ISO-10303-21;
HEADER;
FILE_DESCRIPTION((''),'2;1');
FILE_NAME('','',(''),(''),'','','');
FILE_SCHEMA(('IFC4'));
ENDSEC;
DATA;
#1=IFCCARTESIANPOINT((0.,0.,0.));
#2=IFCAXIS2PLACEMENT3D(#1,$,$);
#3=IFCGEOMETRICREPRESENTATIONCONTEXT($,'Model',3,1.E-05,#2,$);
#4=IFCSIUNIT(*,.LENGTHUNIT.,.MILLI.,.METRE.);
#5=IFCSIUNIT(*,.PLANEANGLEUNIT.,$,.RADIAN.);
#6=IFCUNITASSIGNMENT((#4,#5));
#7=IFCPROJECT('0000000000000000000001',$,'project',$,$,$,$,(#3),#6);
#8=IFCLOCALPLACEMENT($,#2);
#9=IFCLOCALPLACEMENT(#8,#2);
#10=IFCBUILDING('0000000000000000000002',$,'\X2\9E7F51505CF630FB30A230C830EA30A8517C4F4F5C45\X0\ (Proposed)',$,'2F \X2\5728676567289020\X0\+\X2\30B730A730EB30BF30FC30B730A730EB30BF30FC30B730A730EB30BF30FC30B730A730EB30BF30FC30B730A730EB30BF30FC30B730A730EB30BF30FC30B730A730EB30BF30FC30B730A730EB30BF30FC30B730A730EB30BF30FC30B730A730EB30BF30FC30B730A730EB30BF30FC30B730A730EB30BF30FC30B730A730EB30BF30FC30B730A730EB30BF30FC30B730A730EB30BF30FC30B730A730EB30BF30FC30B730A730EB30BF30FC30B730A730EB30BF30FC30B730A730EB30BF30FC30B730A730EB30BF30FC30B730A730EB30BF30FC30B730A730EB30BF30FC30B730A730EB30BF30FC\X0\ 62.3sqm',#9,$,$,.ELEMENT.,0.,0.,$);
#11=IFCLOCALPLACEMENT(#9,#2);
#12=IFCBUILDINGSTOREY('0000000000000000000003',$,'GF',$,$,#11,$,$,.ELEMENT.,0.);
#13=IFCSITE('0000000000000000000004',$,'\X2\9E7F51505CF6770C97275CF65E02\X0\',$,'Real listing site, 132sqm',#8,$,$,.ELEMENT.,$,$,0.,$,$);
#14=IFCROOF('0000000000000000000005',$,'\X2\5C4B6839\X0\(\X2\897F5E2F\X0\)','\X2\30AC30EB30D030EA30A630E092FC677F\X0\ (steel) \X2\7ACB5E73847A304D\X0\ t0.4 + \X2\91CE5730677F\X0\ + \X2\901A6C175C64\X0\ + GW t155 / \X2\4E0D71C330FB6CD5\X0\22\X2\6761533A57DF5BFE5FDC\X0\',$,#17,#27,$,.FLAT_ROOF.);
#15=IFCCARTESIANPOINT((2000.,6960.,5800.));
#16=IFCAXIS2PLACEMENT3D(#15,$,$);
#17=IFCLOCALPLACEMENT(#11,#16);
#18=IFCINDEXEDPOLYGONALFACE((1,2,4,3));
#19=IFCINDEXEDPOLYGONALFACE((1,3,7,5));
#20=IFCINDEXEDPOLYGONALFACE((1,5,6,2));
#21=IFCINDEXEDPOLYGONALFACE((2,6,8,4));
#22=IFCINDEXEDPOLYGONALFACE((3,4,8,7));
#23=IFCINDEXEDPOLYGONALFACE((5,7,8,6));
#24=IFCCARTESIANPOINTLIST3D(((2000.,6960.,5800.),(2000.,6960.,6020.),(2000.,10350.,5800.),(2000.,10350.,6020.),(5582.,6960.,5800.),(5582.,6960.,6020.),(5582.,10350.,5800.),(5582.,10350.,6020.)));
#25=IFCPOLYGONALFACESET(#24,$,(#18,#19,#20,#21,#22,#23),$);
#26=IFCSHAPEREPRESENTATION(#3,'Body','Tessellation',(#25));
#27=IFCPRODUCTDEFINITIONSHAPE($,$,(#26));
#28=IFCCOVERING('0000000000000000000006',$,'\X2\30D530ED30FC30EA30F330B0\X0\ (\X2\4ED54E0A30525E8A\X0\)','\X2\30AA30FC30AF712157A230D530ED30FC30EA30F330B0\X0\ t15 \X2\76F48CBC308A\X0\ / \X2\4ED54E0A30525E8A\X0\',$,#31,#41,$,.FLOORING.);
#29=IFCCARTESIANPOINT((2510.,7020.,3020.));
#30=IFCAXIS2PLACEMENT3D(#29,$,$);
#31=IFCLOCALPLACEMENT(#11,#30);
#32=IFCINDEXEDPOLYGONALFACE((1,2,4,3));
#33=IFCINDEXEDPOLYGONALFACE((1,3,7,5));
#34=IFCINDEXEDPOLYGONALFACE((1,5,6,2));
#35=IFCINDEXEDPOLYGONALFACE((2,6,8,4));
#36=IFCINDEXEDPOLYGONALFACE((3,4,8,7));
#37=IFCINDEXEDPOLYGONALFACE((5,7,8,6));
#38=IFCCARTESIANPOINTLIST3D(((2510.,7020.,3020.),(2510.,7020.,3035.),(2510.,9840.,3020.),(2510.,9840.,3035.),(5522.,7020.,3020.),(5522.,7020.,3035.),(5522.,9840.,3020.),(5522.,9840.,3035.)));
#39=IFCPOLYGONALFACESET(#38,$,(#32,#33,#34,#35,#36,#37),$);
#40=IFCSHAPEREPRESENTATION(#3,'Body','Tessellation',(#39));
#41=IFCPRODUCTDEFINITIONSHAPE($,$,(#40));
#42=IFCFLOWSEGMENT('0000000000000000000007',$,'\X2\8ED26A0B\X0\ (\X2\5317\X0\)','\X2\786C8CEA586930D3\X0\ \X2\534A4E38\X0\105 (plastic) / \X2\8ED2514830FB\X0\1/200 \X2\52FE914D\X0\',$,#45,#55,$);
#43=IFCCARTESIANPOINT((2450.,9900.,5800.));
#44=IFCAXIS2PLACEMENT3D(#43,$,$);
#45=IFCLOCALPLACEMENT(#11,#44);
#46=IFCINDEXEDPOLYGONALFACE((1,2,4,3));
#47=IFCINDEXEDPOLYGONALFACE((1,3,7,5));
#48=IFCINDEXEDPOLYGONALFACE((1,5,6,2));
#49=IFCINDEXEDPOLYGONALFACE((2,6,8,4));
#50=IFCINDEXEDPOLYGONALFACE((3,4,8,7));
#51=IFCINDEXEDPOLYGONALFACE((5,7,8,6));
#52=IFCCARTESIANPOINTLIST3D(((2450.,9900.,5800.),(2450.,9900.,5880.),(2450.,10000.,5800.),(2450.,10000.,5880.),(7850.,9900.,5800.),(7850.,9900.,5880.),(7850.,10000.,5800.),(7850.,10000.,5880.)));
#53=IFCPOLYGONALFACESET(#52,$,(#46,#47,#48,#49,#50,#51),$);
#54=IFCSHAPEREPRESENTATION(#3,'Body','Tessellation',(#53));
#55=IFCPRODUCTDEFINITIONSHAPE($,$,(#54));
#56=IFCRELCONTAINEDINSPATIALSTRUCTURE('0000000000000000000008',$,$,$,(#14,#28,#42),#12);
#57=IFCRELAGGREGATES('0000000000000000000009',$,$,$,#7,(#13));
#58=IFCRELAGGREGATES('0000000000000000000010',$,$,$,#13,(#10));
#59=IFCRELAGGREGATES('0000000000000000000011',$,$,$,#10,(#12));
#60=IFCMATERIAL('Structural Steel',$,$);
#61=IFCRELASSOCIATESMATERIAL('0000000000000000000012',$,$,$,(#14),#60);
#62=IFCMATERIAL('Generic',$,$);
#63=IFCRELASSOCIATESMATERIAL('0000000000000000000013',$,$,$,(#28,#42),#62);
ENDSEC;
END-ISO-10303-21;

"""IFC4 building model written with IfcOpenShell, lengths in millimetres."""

from ifc_helpers import new_model, si_unit, frame, frame_2d, origin, place, context, project, spatial, rectangle, extrude, material, element, save


model = new_model("IFC4")

# Units and contexts
model_context = context("Model", 3, precision=1e-05, world=origin())
ifc_project = project(units=[si_unit("LENGTHUNIT", "METRE", prefix="MILLI"), si_unit("PLANEANGLEUNIT", "RADIAN")], contexts=[model_context])

# Site, building, storey
site_placement = place(None, origin())
site = spatial("IfcSite", under=ifc_project, at=site_placement, Name="鹿児島県霧島市", ObjectType="Real listing site, 132sqm", CompositionType="ELEMENT", RefElevation=0.0)
building_placement = place(site_placement, origin())
building = spatial("IfcBuilding", under=site, at=building_placement, Name="鹿児島・アトリエ兼住居 (Proposed)", ObjectType="2F 在来木造+シェルターシェルターシェルターシェルターシェルターシェルターシェルターシェルターシェルターシェルターシェルターシェルターシェルターシェルターシェルターシェルターシェルターシェルターシェルターシェルターシェルターシェルターシェルター 62.3sqm", CompositionType="ELEMENT", ElevationOfRefHeight=0.0, ElevationOfTerrain=0.0)
storey_placement = place(building_placement, origin())
storey = spatial("IfcBuildingStorey", under=building, at=storey_placement, Name="GF", CompositionType="ELEMENT", Elevation=0.0)

# Roof
ifc_material_1 = material(Name="Structural Steel")
for number, where, name in (
    (1, (2000.0, 6960.0, 5800.0), "屋根(西帯)"),
):
    element("IfcRoof", number, at=place(storey_placement, frame(where)), inside=storey, material=ifc_material_1, Name=name, Description="ガルバリウム鋼板 (steel) 立平葺き t0.4 + 野地板 + 通気層 + GW t155 / 不燃・法22条区域対応", PredefinedType="FLAT_ROOF", context=model_context, shape_type="SweptSolid", body=[
        extrude(rectangle(XDim=3582.0, YDim=3390.0, at=frame_2d((1791.0, 1695.0))), frame((2000.0, 6960.0, 5800.0)), (0.0, 0.0, 1.0), 220.0),
    ])

# Covering
ifc_material_2 = material(Name="Generic")
covering_placement = place(storey_placement, frame((2510.0, 7020.0, 3020.0)))
element("IfcCovering", 2, at=covering_placement, inside=storey, material=ifc_material_2, Name="フローリング (仕上げ床)", Description="オーク無垢フローリング t15 直貼り / 仕上げ床", PredefinedType="FLOORING", context=model_context, shape_type="SweptSolid", body=[
    extrude(rectangle(XDim=3012.0, YDim=2820.0, at=frame_2d((1506.0, 1410.0))), frame((2510.0, 7020.0, 3020.0)), (0.0, 0.0, 1.0), 15.0),
])

# Flow segment
flow_segment_placement = place(storey_placement, frame((2450.0, 9900.0, 5800.0)))
element("IfcFlowSegment", 3, at=flow_segment_placement, inside=storey, material=ifc_material_2, Name="軒樋 (北)", Description="硬質塩ビ 半丸105 (plastic) / 軒先・1/200 勾配", context=model_context, shape_type="SweptSolid", body=[
    extrude(rectangle(XDim=5400.0, YDim=100.0, at=frame_2d((2700.0, 50.0))), frame((2450.0, 9900.0, 5800.0)), (0.0, 0.0, 1.0), 80.0),
])

save(model, "model.ifc")
